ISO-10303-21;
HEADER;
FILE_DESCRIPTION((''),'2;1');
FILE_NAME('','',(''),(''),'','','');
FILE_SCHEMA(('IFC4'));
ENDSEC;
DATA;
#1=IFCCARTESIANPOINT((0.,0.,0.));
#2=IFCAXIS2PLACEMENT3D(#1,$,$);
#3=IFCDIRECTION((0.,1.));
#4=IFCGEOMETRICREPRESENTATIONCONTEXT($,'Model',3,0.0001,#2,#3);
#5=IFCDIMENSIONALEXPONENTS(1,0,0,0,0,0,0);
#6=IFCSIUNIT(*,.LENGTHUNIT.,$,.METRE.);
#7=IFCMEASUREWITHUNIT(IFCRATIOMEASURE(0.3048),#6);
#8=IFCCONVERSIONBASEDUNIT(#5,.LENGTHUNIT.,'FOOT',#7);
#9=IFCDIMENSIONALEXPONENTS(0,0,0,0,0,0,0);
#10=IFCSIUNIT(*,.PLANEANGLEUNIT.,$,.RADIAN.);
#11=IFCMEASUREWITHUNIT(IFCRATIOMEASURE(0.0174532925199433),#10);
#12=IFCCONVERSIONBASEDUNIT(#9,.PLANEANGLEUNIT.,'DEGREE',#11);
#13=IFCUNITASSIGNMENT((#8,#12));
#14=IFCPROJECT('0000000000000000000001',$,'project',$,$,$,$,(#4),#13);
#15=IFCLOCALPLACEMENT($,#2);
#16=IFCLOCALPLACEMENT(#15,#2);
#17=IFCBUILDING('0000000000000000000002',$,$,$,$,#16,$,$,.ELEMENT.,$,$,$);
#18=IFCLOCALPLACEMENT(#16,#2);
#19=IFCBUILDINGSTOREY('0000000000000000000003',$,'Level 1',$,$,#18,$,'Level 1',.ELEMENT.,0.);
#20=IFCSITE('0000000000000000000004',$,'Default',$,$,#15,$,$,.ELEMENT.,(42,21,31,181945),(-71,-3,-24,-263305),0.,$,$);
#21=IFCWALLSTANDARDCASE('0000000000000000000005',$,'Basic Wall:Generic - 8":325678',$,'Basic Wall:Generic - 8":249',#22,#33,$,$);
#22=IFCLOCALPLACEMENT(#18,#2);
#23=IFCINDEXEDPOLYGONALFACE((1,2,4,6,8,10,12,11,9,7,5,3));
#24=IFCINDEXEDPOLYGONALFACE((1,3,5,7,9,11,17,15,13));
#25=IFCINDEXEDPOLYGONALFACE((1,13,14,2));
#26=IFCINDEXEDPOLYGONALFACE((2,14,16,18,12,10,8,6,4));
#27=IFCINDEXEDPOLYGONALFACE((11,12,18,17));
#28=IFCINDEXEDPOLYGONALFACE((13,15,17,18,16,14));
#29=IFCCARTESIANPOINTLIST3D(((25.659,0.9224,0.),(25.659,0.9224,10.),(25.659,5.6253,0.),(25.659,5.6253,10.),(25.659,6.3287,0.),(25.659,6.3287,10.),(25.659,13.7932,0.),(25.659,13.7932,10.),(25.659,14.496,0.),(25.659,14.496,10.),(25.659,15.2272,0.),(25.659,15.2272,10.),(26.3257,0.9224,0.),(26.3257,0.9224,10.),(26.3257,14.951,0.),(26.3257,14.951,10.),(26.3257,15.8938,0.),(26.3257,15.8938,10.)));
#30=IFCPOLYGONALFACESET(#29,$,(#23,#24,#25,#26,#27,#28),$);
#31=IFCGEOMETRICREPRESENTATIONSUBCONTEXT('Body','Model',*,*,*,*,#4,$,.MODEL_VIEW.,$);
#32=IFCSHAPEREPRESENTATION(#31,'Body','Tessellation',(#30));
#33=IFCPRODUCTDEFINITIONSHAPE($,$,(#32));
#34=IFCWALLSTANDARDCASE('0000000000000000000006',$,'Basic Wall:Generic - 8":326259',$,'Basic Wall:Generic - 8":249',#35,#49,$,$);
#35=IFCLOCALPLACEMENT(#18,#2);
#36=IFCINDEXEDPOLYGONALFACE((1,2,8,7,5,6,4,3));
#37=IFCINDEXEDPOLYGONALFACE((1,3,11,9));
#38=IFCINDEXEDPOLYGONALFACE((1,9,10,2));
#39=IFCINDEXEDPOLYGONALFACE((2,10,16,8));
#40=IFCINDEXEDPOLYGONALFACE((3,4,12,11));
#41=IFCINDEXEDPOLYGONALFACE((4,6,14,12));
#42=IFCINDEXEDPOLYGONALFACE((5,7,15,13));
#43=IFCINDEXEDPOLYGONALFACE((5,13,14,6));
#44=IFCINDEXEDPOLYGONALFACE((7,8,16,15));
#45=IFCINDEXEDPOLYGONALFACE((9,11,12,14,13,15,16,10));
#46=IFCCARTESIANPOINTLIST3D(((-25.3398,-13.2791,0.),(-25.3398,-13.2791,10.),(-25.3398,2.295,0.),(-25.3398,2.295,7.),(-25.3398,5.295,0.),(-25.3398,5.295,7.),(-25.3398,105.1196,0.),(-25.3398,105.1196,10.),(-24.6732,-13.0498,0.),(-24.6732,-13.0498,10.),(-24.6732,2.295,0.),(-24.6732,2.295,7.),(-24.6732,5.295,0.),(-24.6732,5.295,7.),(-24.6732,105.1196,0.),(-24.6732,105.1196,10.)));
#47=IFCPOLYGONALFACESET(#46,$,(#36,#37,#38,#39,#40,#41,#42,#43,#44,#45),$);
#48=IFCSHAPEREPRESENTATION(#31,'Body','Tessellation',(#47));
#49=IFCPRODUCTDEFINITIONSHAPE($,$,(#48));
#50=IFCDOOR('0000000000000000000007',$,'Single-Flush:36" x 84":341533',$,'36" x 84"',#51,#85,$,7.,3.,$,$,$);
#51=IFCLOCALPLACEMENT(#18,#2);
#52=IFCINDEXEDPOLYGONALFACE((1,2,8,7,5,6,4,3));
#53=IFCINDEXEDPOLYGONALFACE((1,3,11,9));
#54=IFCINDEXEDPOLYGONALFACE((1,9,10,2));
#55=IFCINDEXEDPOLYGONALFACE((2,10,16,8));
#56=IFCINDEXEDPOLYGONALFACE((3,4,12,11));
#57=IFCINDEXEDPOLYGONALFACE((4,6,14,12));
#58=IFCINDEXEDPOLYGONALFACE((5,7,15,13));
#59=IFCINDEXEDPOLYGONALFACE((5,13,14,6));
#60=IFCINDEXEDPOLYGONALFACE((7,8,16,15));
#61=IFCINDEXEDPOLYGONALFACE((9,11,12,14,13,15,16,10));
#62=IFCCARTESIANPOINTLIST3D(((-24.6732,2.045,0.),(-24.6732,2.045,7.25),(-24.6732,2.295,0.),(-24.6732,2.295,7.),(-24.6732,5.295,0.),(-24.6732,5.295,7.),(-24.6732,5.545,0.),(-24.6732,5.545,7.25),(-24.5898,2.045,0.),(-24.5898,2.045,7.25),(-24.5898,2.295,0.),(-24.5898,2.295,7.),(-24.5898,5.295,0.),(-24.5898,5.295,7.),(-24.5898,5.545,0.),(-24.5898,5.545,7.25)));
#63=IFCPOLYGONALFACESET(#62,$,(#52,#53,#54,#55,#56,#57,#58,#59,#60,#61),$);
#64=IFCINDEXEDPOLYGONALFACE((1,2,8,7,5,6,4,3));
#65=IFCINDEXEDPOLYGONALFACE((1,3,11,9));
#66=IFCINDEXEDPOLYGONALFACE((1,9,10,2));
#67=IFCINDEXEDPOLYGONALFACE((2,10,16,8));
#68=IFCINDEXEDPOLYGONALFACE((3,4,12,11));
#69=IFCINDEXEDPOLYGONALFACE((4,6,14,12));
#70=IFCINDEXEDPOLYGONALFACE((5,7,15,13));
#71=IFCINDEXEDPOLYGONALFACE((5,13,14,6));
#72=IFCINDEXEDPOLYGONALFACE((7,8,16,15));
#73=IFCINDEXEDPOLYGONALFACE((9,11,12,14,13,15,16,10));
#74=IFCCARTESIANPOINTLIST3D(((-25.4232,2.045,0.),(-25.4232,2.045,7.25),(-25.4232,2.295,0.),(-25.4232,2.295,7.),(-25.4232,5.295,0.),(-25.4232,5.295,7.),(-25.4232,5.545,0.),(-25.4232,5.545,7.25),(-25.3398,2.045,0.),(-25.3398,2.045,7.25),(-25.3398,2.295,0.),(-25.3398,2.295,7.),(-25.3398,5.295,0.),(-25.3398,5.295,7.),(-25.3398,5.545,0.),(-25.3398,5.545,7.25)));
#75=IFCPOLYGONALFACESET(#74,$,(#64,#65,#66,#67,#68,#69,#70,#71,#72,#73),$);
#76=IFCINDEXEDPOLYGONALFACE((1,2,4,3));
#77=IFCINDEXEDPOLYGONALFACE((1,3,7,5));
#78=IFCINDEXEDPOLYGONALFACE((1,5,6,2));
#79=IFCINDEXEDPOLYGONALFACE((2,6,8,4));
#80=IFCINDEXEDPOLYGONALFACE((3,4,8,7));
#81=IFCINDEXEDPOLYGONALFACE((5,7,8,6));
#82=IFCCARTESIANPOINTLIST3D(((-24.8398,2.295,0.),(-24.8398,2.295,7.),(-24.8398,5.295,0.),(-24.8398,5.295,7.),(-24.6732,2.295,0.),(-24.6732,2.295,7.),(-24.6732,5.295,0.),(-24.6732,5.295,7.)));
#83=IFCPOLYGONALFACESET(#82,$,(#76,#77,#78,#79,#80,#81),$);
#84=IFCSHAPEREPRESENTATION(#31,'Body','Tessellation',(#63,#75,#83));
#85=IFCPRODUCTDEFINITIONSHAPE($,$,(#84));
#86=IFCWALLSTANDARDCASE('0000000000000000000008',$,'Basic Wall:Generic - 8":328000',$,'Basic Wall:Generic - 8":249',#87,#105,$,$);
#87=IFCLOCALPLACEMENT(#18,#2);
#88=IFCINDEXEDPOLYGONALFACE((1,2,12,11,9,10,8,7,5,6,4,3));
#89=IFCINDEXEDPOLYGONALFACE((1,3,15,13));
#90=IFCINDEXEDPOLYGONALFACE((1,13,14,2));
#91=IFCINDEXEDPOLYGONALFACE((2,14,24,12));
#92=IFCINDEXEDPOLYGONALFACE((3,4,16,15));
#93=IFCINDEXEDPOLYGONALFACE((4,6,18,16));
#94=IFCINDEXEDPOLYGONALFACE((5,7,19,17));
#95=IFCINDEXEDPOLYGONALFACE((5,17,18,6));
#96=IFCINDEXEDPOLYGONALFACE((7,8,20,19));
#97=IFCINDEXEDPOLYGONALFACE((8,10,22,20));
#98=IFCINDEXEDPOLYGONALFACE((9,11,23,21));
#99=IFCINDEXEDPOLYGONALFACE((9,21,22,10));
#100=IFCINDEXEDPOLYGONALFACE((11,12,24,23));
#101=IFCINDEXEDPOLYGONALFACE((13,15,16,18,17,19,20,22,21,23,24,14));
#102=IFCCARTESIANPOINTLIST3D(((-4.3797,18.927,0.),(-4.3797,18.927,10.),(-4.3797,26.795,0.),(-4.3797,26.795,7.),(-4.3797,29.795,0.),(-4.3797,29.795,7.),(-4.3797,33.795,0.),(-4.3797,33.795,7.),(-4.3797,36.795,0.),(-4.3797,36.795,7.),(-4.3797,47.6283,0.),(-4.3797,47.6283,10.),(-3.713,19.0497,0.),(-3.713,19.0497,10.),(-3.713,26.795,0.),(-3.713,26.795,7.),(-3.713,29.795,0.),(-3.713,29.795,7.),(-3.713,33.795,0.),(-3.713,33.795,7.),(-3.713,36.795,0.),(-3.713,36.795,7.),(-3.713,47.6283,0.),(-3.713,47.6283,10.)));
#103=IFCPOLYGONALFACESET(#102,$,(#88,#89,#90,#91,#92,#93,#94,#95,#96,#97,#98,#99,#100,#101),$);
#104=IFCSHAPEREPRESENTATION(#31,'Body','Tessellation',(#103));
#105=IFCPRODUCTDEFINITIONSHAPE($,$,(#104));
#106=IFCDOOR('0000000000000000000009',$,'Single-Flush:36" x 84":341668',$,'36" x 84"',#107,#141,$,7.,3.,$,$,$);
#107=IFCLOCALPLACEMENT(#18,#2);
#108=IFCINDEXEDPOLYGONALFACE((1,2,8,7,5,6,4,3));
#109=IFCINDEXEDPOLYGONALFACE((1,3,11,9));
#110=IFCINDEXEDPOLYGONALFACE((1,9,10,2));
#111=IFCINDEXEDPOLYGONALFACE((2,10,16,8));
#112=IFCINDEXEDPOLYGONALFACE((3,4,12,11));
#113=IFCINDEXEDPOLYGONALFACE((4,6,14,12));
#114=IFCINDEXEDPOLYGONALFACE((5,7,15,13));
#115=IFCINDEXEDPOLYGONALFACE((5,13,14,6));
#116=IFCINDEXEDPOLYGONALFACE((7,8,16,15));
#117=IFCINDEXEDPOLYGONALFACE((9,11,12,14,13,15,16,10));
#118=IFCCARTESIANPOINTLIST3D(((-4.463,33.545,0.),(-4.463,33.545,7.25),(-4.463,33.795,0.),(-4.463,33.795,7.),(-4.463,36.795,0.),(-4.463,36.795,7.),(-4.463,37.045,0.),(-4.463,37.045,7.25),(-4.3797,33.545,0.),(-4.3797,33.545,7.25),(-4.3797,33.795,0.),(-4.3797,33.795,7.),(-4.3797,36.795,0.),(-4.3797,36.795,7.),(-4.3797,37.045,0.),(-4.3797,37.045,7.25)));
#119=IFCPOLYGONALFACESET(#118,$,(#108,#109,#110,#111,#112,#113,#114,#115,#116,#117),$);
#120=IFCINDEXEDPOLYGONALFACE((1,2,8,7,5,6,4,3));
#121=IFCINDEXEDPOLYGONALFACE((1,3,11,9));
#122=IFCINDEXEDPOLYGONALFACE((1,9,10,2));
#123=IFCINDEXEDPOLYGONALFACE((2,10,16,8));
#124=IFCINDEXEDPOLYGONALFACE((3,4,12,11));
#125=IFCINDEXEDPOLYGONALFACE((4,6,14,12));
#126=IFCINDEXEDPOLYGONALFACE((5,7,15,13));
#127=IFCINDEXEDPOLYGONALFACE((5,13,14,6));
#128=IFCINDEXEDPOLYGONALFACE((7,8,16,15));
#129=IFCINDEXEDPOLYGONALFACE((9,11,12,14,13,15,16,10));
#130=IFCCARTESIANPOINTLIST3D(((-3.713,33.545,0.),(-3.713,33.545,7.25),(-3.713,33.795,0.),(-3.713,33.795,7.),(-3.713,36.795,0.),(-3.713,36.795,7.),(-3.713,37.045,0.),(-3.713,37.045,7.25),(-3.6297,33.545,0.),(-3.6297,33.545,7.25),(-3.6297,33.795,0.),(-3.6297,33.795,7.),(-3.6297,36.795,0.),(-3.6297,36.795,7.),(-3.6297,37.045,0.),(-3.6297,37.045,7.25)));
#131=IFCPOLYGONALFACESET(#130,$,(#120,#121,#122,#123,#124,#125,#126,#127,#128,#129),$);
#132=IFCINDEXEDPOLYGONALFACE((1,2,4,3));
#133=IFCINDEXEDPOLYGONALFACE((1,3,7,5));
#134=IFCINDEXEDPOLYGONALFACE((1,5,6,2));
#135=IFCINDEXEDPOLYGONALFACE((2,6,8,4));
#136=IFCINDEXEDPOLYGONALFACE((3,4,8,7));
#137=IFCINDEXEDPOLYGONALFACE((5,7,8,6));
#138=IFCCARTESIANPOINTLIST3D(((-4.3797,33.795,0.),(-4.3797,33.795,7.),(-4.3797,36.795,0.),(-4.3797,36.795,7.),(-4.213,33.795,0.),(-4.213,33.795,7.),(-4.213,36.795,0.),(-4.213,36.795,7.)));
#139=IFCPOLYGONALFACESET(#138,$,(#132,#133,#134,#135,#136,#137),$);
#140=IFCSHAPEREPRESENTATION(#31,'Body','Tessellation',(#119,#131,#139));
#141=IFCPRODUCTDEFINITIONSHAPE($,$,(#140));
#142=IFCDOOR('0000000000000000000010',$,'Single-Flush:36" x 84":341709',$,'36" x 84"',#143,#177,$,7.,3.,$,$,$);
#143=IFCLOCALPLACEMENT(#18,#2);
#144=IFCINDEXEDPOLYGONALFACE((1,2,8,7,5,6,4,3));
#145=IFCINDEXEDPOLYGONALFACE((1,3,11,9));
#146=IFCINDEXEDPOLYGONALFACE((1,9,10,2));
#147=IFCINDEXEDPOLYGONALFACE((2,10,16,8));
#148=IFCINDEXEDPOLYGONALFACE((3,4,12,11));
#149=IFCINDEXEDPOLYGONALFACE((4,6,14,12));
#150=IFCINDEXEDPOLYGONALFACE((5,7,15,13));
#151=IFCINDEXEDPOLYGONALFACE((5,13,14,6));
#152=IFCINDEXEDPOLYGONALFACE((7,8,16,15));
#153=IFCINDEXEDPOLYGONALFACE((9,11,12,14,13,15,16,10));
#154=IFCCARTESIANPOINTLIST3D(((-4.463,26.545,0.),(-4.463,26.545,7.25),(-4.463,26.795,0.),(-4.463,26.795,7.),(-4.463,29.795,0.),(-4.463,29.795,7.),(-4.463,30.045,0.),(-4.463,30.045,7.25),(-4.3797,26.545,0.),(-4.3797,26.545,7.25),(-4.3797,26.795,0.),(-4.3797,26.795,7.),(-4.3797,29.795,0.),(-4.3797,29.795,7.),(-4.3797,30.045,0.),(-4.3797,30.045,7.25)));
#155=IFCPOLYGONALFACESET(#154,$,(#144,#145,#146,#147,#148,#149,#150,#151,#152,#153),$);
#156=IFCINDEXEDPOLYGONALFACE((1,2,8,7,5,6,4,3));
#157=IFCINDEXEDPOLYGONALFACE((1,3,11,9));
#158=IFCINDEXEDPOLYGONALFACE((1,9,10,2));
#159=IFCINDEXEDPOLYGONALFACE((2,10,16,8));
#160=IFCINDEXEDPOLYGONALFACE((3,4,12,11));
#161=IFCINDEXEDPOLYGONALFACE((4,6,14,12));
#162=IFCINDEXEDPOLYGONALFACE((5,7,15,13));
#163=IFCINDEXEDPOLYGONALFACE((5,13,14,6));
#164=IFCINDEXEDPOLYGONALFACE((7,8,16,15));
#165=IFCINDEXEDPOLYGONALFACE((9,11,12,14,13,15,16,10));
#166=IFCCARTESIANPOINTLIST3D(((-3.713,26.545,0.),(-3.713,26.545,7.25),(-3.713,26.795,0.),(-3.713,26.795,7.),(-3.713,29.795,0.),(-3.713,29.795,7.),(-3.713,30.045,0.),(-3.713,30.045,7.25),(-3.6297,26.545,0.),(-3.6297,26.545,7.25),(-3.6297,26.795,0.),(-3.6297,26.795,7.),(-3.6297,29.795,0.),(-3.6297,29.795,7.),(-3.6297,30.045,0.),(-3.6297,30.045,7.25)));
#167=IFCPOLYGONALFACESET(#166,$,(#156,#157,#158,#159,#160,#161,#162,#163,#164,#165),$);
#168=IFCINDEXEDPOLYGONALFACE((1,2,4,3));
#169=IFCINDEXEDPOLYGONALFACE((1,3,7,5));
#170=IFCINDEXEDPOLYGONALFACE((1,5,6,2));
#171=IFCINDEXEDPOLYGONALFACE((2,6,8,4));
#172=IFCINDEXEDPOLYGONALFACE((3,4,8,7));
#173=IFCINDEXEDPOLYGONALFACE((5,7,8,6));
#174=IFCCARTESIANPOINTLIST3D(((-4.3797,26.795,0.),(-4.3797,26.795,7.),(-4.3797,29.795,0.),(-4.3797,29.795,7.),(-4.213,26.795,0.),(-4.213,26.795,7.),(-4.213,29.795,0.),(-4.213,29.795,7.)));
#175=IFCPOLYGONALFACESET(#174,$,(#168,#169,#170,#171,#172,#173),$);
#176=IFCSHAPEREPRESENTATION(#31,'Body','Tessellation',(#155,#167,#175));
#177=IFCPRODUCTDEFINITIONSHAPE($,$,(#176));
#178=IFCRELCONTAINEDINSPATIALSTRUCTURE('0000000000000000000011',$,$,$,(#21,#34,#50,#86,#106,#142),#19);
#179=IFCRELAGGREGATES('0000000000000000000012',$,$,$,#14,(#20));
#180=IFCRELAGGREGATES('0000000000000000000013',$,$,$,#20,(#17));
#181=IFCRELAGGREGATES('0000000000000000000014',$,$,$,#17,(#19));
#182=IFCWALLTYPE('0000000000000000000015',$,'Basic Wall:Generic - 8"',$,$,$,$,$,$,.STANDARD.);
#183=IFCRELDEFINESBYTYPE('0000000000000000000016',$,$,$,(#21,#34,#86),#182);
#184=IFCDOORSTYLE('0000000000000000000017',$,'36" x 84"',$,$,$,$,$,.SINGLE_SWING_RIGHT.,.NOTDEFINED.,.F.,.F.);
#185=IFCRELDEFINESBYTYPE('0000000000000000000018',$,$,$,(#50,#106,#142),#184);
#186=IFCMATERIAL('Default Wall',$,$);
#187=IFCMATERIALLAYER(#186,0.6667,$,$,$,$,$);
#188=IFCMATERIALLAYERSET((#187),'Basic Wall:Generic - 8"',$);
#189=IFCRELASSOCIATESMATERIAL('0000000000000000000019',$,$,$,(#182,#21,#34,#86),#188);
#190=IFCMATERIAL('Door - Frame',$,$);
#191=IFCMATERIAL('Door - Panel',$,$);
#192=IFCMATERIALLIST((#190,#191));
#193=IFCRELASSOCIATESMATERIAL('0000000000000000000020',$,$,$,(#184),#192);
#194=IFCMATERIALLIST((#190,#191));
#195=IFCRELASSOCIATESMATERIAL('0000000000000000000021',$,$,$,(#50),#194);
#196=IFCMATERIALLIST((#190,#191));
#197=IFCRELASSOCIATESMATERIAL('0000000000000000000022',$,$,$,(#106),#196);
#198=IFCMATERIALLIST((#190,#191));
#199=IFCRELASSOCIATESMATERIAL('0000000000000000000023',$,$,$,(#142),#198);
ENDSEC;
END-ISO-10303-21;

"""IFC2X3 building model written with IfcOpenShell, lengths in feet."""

from ifc_helpers import new_model, entity, si_unit, converted_unit, direction, frame, frame_2d, origin, place, context, subcontext, project, spatial, polyline, rectangle, outline, extrude, source, transform, mapped, material, material_list, layer, layer_set, layer_usage, type_object, type_shapes, element, fill, save


model = new_model("IFC2X3")

# Units and contexts
model_context = context("Model", 3, precision=0.0001, world=origin(), true_north=direction((0.0, 1.0)))
body_context = subcontext(model_context, "Body", "Model", "MODEL_VIEW")
ifc_project = project(units=[converted_unit("LENGTHUNIT", "FOOT", entity("IfcRatioMeasure", 0.3048), si_unit("LENGTHUNIT", "METRE"), dimensions=[1, 0, 0, 0, 0, 0, 0]), converted_unit("PLANEANGLEUNIT", "DEGREE", entity("IfcRatioMeasure", 0.0174532925199433), si_unit("PLANEANGLEUNIT", "RADIAN"), dimensions=[0, 0, 0, 0, 0, 0, 0])], contexts=[model_context])

# Site, building, storey
site_placement = place(None, origin())
site = spatial("IfcSite", under=ifc_project, at=site_placement, Name="Default", CompositionType="ELEMENT", RefLatitude=(42, 21, 31, 181945), RefLongitude=(-71, -3, -24, -263305), RefElevation=0.0)
building_placement = place(site_placement, origin())
building = spatial("IfcBuilding", under=site, at=building_placement, CompositionType="ELEMENT")
storey_placement = place(building_placement, origin())
storey = spatial("IfcBuildingStorey", under=building, at=storey_placement, Name="Level 1", LongName="Level 1", CompositionType="ELEMENT", Elevation=0.0)

# Wall
ifc_material_1 = material(Name="Default Wall")
ifc_layer = layer(ifc_material_1, 0.6667)
ifc_layer_set = layer_set([ifc_layer], Name="Basic Wall:Generic - 8\"")
ifc_layer_usage_1 = layer_usage(ifc_layer_set, "AXIS2", "NEGATIVE", 0.3333)
wall_type = type_object("IfcWallType", Name="Basic Wall:Generic - 8\"", PredefinedType="STANDARD", material=ifc_layer_set)
wall_1_placement = place(storey_placement, frame((25.9923, 0.9224, 0.0), z_axis=(0.0, 0.0, 1.0), x_axis=(0.0, 1.0, 0.0)))
element("IfcWallStandardCase", 1, at=wall_1_placement, inside=storey, type_object=wall_type, material=ifc_layer_usage_1, Name="Basic Wall:Generic - 8\":325678", ObjectType="Basic Wall:Generic - 8\":249", context=body_context, shape_type="SweptSolid", body=[
    extrude(outline(polyline([(14.9714, -0.3333), (14.3047, 0.3333), (13.5735, 0.3333), (12.8708, 0.3333), (5.4062, 0.3333), (4.7029, 0.3333), (0.0, 0.3333), (0.0, -0.3333), (14.0286, -0.3333), (14.9714, -0.3333)])), origin(), (0.0, 0.0, 1.0), 10.0),
])

# Shared definitions
ifc_material_2 = material(Name="Door - Frame")
ifc_material_3 = material(Name="Door - Panel")
ifc_material_list_1 = material_list([ifc_material_2, ifc_material_3])
door_style = type_object("IfcDoorStyle", Name="36\" x 84\"", ConstructionType="NOTDEFINED", OperationType="SINGLE_SWING_RIGHT", ParameterTakesPrecedence=False, Sizeable=False, material=ifc_material_list_1)
shared_shape = source(origin(), body_context, "Body", "SweptSolid", [
    extrude(outline(polyline([(-1.75, -3.6875), (1.75, -3.6875), (1.75, 3.5625), (1.5, 3.5625), (1.5, -3.4375), (-1.5, -3.4375), (-1.5, 3.5625), (-1.75, 3.5625), (-1.75, -3.6875)])), frame((1.5, 0.6667, 3.5625), z_axis=(0.0, 1.0, 0.0), x_axis=(1.0, 0.0, 0.0)), (0.0, 0.0, 1.0), 0.0833),
    extrude(outline(polyline([(-3.6875, -1.75), (3.5625, -1.75), (3.5625, -1.5), (-3.4375, -1.5), (-3.4375, 1.5), (3.5625, 1.5), (3.5625, 1.75), (-3.6875, 1.75), (-3.6875, -1.75)])), frame((1.5, -0.0833, 3.5625), z_axis=(0.0, 1.0, 0.0), x_axis=(0.0, 0.0, -1.0)), (0.0, 0.0, 1.0), 0.0833),
    extrude(rectangle(XDim=0.1667, YDim=3.0, at=frame_2d((0.0, 0.0), x_axis=(1.0, 0.0))), frame((1.5, 0.5833, 0.0), z_axis=(0.0, 0.0, 1.0), x_axis=(0.0, 1.0, 0.0)), (0.0, 0.0, 1.0), 7.0),
])
type_shapes(door_style, [shared_shape])

# Wall, opening, door
ifc_layer_usage_2 = layer_usage(ifc_layer_set, "AXIS2", "NEGATIVE", 0.3333)
wall_2_placement = place(storey_placement, frame((-25.0065, -13.2791, 0.0), z_axis=(0.0, 0.0, 1.0), x_axis=(0.0, 1.0, 0.0)))
wall_2 = element("IfcWallStandardCase", 2, at=wall_2_placement, inside=storey, type_object=wall_type, material=ifc_layer_usage_2, Name="Basic Wall:Generic - 8\":326259", ObjectType="Basic Wall:Generic - 8\":249", context=body_context, shape_type="SweptSolid", body=[
    extrude(outline(polyline([(0.2293, -0.3333), (30.2365, -0.3333), (30.9134, -0.3333), (36.7408, -0.3333), (37.4075, -0.3333), (44.2408, -0.3333), (44.9075, -0.3333), (73.0654, -0.3333), (73.7321, -0.3333), (106.5654, -0.3333), (107.2321, -0.3333), (118.3988, -0.3333), (118.3988, 0.3333), (0.0, 0.3333), (0.2293, -0.3333)])), origin(), (0.0, 0.0, 1.0), 10.0),
])
opening_1_placement = place(wall_2_placement, frame((18.5741, 0.3333, 0.0)))
opening_1 = element("IfcOpeningElement", 3, at=opening_1_placement, cuts=wall_2, ObjectType="Opening", context=body_context, shape_type="SweptSolid", body=[
    extrude(rectangle(XDim=3.0, YDim=7.0, at=frame_2d((3.5, 1.5), x_axis=(0.0, 1.0))), frame((0.0, 0.0, 0.0), z_axis=(0.0, -1.0, 0.0), x_axis=(0.0, 0.0, 1.0)), (0.0, 0.0, 1.0), 0.6667),
])
ifc_material_list_2 = material_list([ifc_material_2, ifc_material_3])
door_1_placement = place(opening_1_placement, frame((0.0, 0.0, 0.0), z_axis=(0.0, 0.0, 1.0), x_axis=(-1.0, 0.0, 0.0)))
door_1 = element("IfcDoor", 4, at=door_1_placement, inside=storey, type_object=door_style, material=ifc_material_list_2, Name="Single-Flush:36\" x 84\":341533", ObjectType="36\" x 84\"", OverallHeight=7.0, OverallWidth=3.0, context=body_context, shape_type="MappedRepresentation", body=[
    mapped(shared_shape, transform((0.0, 0.0, 0.0), scale=1.0)),
])
fill(opening_1, door_1)

# Wall, openings, doors
ifc_layer_usage_3 = layer_usage(ifc_layer_set, "AXIS2", "NEGATIVE", 0.3333)
wall_3_placement = place(storey_placement, frame((-4.0463, 47.6283, 0.0), z_axis=(0.0, 0.0, 1.0), x_axis=(0.0, -1.0, 0.0)))
wall_3 = element("IfcWallStandardCase", 5, at=wall_3_placement, inside=storey, type_object=wall_type, material=ifc_layer_usage_3, Name="Basic Wall:Generic - 8\":328000", ObjectType="Basic Wall:Generic - 8\":249", context=body_context, shape_type="SweptSolid", body=[
    extrude(outline(polyline([(0.0, -0.3333), (16.0, -0.3333), (16.6667, -0.3333), (28.0235, -0.3333), (28.7014, -0.3333), (28.5787, 0.3333), (0.6667, 0.3333), (0.0, 0.3333), (0.0, -0.3333)])), origin(), (0.0, 0.0, 1.0), 10.0),
])
opening_2_placement = place(wall_3_placement, frame((13.8333, 0.3333, 0.0)))
opening_2 = element("IfcOpeningElement", 6, at=opening_2_placement, cuts=wall_3, ObjectType="Opening", context=body_context, shape_type="SweptSolid", body=[
    extrude(rectangle(XDim=3.0, YDim=7.0, at=frame_2d((3.5, 1.5), x_axis=(0.0, 1.0))), frame((0.0, 0.0, 0.0), z_axis=(0.0, -1.0, 0.0), x_axis=(0.0, 0.0, 1.0)), (0.0, 0.0, 1.0), 0.6667),
])
opening_3_placement = place(wall_3_placement, frame((20.8333, 0.3333, 0.0)))
opening_3 = element("IfcOpeningElement", 7, at=opening_3_placement, cuts=wall_3, ObjectType="Opening", context=body_context, shape_type="SweptSolid", body=[
    extrude(rectangle(XDim=3.0, YDim=7.0, at=frame_2d((3.5, 1.5), x_axis=(0.0, 1.0))), frame((0.0, 0.0, 0.0), z_axis=(0.0, -1.0, 0.0), x_axis=(0.0, 0.0, 1.0)), (0.0, 0.0, 1.0), 0.6667),
])
ifc_material_list_3 = material_list([ifc_material_2, ifc_material_3])
door_2_placement = place(opening_2_placement, frame((0.0, 0.0, 0.0), z_axis=(0.0, 0.0, 1.0), x_axis=(-1.0, 0.0, 0.0)))
door_2 = element("IfcDoor", 8, at=door_2_placement, inside=storey, type_object=door_style, material=ifc_material_list_3, Name="Single-Flush:36\" x 84\":341668", ObjectType="36\" x 84\"", OverallHeight=7.0, OverallWidth=3.0, context=body_context, shape_type="MappedRepresentation", body=[
    mapped(shared_shape, transform((0.0, 0.0, 0.0), scale=1.0)),
])
fill(opening_2, door_2)
ifc_material_list_4 = material_list([ifc_material_2, ifc_material_3])
door_3_placement = place(opening_3_placement, frame((0.0, 0.0, 0.0), z_axis=(0.0, 0.0, 1.0), x_axis=(-1.0, 0.0, 0.0)))
door_3 = element("IfcDoor", 9, at=door_3_placement, inside=storey, type_object=door_style, material=ifc_material_list_4, Name="Single-Flush:36\" x 84\":341709", ObjectType="36\" x 84\"", OverallHeight=7.0, OverallWidth=3.0, context=body_context, shape_type="MappedRepresentation", body=[
    mapped(shared_shape, transform((0.0, 0.0, 0.0), scale=1.0)),
])
fill(opening_3, door_3)

save(model, "model.ifc")
